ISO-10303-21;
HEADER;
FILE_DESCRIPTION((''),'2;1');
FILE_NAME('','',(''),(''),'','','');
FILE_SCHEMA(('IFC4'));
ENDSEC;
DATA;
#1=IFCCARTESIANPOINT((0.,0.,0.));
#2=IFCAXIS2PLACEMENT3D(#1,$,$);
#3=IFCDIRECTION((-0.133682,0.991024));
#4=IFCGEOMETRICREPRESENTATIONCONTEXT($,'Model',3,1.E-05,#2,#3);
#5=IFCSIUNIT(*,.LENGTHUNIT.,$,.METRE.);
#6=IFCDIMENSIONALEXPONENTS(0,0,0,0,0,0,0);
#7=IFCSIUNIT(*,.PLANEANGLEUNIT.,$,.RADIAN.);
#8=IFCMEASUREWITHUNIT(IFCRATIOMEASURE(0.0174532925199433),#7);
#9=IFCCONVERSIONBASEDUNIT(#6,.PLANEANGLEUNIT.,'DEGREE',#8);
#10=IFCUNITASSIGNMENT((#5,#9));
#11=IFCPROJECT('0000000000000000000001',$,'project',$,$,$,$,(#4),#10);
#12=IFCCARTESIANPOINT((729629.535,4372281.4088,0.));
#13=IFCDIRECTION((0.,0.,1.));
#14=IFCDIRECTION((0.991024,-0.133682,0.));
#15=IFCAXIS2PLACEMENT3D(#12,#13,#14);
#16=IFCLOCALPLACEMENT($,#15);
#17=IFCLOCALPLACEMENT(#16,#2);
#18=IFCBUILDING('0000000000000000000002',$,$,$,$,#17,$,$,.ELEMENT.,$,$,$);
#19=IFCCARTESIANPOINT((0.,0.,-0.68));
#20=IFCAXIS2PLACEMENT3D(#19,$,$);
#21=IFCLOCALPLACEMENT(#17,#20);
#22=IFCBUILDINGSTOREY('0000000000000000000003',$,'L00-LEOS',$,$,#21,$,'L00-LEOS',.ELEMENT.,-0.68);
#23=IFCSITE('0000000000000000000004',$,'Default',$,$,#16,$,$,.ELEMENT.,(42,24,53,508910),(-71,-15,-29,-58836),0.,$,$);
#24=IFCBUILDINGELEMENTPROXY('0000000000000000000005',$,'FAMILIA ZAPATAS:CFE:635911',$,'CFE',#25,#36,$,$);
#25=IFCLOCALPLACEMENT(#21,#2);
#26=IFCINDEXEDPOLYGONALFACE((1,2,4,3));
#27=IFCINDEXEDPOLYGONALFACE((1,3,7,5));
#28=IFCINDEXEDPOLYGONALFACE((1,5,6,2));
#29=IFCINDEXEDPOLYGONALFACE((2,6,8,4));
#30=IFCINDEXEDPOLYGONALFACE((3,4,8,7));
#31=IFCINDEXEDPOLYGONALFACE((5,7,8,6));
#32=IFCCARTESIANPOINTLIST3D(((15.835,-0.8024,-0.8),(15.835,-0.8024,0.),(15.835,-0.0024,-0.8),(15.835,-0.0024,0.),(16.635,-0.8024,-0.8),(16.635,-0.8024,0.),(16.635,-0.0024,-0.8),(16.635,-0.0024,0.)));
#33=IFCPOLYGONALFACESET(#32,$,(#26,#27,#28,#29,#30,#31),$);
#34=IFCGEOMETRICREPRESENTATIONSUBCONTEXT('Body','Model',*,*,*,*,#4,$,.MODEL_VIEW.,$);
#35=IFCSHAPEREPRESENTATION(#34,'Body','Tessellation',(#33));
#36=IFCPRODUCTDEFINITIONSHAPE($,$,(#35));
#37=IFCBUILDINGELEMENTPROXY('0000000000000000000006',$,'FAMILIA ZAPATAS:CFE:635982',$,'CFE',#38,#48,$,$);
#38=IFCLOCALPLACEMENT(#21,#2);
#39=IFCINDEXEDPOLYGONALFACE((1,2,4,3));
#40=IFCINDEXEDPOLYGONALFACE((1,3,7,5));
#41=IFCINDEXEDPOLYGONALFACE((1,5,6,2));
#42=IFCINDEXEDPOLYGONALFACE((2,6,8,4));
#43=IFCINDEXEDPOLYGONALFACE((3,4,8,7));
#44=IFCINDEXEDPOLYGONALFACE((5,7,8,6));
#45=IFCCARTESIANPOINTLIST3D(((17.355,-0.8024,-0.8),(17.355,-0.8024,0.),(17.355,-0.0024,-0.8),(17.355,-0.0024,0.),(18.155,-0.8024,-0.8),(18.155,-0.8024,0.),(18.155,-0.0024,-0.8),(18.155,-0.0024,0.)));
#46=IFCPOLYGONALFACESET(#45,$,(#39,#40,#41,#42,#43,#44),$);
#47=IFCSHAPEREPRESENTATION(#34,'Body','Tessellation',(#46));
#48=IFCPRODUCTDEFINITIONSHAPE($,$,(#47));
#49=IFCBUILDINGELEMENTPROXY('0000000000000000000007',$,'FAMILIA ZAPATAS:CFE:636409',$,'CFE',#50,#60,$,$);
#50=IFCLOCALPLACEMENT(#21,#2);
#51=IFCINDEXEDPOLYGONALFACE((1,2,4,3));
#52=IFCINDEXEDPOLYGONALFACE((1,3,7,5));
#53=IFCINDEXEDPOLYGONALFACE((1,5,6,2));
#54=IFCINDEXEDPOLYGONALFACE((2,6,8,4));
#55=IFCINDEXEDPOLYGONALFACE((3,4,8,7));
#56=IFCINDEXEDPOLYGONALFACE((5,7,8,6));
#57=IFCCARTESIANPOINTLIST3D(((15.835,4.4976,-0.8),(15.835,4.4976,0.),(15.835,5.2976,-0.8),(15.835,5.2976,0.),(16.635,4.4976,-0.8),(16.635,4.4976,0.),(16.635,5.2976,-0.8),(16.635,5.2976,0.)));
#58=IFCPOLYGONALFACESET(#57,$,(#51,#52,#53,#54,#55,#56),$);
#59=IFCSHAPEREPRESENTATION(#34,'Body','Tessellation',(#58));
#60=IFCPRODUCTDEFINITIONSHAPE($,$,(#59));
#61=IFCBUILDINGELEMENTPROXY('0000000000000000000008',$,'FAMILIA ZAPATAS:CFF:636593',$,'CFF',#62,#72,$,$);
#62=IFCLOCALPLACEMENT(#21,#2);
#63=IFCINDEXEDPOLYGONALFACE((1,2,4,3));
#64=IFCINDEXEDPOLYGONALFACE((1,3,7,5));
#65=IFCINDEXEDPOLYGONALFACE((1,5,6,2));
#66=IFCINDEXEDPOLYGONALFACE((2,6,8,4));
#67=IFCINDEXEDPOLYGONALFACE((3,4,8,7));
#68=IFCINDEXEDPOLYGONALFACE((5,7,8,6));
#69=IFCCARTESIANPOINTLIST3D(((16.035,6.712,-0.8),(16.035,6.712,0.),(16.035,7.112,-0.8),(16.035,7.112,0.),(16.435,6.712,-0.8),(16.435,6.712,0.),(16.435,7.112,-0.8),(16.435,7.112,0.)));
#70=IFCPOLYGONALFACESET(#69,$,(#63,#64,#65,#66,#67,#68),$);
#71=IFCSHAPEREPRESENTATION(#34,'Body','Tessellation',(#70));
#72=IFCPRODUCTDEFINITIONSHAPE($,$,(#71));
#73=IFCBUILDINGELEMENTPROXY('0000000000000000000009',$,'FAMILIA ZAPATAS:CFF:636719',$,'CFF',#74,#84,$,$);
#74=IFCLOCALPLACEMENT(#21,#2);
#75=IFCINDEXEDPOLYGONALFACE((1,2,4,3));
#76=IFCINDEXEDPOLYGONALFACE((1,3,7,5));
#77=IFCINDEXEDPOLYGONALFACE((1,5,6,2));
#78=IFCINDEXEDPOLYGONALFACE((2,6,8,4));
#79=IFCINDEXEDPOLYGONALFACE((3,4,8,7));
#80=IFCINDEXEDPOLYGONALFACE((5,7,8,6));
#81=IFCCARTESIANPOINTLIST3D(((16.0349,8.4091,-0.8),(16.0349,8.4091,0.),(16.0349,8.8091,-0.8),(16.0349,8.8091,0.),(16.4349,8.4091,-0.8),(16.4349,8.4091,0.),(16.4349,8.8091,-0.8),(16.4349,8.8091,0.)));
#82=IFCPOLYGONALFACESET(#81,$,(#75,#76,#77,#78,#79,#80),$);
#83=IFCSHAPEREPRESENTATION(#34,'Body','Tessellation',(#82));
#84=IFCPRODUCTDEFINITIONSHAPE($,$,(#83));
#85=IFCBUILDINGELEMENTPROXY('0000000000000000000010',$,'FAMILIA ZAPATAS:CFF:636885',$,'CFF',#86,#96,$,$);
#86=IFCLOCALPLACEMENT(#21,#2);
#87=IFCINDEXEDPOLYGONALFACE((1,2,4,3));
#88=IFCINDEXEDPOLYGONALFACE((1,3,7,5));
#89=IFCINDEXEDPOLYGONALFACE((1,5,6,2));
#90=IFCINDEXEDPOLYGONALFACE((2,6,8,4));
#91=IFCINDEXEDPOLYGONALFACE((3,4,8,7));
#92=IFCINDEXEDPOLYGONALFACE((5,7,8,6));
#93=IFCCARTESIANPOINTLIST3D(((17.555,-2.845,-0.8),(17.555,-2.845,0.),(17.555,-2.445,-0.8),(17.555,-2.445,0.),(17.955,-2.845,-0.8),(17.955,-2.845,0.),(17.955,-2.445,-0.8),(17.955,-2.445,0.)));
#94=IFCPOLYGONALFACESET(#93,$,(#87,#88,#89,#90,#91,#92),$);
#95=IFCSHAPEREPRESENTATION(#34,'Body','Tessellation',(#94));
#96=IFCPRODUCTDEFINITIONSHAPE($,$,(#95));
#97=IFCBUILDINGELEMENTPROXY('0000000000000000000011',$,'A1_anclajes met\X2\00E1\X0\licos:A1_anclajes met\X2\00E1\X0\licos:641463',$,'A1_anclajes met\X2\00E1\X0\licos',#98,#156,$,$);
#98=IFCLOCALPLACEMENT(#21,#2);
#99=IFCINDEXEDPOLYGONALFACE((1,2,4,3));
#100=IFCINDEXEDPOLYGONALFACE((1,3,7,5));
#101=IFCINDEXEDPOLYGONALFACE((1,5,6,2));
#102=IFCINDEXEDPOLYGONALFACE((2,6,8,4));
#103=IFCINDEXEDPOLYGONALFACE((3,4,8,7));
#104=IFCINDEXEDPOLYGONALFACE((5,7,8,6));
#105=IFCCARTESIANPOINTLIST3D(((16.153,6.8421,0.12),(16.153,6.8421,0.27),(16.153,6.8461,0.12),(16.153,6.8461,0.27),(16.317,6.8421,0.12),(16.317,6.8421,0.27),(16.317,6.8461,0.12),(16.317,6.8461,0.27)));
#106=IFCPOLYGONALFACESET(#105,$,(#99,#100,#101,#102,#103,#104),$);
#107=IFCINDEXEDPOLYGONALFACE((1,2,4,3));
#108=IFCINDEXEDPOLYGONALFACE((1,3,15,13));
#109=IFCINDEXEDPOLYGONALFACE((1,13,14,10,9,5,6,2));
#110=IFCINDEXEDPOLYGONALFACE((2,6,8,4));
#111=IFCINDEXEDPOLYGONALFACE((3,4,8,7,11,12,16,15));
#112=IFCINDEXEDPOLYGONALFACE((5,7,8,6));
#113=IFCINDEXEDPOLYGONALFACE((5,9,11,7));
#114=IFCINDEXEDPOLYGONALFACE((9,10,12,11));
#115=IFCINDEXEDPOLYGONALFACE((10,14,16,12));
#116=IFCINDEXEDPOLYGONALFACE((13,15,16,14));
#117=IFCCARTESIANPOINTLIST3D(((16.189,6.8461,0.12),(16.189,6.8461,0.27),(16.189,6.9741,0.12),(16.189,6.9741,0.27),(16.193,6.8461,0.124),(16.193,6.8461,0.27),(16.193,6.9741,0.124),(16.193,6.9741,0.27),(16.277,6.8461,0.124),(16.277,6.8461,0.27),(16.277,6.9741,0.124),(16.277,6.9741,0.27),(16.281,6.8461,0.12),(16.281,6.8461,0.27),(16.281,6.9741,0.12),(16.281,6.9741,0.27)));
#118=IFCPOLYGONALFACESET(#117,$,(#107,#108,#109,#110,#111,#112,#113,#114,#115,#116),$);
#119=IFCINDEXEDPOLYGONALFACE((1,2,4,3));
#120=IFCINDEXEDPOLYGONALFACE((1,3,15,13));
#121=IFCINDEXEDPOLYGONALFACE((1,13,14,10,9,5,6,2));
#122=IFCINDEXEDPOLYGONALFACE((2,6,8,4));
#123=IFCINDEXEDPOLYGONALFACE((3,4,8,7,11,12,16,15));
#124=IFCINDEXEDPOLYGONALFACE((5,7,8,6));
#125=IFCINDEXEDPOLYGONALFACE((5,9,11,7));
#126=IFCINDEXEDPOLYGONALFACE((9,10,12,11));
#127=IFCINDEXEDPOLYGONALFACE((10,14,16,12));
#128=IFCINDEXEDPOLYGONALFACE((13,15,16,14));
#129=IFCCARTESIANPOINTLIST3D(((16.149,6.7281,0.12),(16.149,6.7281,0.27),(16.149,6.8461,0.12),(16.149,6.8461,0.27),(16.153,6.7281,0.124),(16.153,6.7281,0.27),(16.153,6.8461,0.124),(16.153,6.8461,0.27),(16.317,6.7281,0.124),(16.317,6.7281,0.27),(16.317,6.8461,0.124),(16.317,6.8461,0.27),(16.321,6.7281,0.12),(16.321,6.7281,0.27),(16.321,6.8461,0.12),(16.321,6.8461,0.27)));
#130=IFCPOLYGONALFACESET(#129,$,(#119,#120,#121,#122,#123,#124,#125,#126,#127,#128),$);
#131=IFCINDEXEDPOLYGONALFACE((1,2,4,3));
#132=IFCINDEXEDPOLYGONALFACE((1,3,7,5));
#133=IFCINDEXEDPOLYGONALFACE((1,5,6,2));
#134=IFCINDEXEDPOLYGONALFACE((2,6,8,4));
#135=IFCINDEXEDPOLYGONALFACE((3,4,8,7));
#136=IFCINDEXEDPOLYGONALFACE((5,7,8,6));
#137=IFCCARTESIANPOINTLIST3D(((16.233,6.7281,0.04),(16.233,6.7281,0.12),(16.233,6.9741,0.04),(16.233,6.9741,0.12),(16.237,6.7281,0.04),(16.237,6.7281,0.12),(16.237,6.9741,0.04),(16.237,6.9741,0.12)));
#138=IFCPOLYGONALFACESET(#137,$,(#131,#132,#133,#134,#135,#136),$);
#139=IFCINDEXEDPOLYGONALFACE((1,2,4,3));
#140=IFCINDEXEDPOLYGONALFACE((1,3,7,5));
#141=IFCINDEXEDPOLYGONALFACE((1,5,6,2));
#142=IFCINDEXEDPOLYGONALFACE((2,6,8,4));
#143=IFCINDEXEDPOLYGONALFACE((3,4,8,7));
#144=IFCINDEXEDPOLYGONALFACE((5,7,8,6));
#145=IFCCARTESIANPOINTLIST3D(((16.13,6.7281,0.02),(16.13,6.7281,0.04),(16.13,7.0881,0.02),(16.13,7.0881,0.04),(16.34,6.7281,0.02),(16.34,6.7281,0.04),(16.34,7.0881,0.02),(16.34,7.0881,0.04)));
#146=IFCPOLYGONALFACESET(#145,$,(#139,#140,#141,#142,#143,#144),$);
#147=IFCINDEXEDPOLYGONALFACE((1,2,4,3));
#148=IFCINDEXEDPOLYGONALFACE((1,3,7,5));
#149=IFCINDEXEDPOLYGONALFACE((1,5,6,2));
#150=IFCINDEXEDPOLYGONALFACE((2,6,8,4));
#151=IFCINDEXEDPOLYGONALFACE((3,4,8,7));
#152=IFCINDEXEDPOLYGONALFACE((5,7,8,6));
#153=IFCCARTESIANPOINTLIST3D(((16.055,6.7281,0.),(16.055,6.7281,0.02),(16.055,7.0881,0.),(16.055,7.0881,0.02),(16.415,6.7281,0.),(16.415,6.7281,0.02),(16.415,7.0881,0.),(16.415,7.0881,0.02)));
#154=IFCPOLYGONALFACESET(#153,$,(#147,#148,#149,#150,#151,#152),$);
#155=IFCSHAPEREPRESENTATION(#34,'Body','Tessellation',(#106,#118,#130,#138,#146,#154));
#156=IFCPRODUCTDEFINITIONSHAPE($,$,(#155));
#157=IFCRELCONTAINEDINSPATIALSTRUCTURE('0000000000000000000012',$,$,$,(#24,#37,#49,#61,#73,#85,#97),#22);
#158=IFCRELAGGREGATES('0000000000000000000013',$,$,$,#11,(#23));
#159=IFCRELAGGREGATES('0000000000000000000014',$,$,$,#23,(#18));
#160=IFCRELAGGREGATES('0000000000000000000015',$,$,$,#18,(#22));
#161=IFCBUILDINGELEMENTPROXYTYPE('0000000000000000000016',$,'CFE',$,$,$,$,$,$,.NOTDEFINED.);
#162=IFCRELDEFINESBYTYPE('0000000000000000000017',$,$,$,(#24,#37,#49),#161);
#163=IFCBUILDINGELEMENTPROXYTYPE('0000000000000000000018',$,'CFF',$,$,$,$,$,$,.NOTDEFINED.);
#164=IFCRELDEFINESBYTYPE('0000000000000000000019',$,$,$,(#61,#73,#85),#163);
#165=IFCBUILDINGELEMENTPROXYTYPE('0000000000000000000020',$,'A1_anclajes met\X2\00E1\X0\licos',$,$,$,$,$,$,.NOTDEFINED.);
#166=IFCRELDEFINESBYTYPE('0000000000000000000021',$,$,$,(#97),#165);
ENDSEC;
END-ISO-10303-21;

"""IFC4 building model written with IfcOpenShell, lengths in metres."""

from ifc_helpers import new_model, entity, si_unit, converted_unit, direction, frame, frame_2d, origin, origin_2d_with_axis, place, context, subcontext, project, spatial, polyline, rectangle, outline, extrude, source, transform, mapped, type_object, type_shapes, element, save


model = new_model("IFC4")

# Units and contexts
model_context = context("Model", 3, precision=1e-05, world=origin(), true_north=direction((-0.133682, 0.991024)))
body_context = subcontext(model_context, "Body", "Model", "MODEL_VIEW")
ifc_project = project(units=[si_unit("LENGTHUNIT", "METRE"), converted_unit("PLANEANGLEUNIT", "DEGREE", entity("IfcRatioMeasure", 0.0174532925199433), si_unit("PLANEANGLEUNIT", "RADIAN"), dimensions=[0, 0, 0, 0, 0, 0, 0])], contexts=[model_context])

# Site, building, storey
site_placement = place(None, frame((729629.535, 4372281.4088, 0.0), z_axis=(0.0, 0.0, 1.0), x_axis=(0.991024, -0.133682, 0.0)))
site = spatial("IfcSite", under=ifc_project, at=site_placement, Name="Default", CompositionType="ELEMENT", RefLatitude=(42, 24, 53, 508910), RefLongitude=(-71, -15, -29, -58836), RefElevation=0.0)
building_placement = place(site_placement, origin())
building = spatial("IfcBuilding", under=site, at=building_placement, CompositionType="ELEMENT")
storey_placement = place(building_placement, frame((0.0, 0.0, -0.68)))
storey = spatial("IfcBuildingStorey", under=building, at=storey_placement, Name="L00-LEOS", LongName="L00-LEOS", CompositionType="ELEMENT", Elevation=-0.68)

# Building element proxies
building_element_proxy_type_1 = type_object("IfcBuildingElementProxyType", Name="CFE")
shared_shape_1 = source(origin(), body_context, "Body", "SweptSolid", [
    extrude(rectangle(XDim=0.8, YDim=0.8, at=origin_2d_with_axis()), frame((0.0, 0.0, 0.0), z_axis=(0.0, 0.0, 1.0), x_axis=(0.0, -1.0, 0.0)), (0.0, 0.0, 1.0), 0.8),
])
type_shapes(building_element_proxy_type_1, [shared_shape_1])
for number, where, name in (
    (1, (16.235, -0.4024, -0.8), "FAMILIA ZAPATAS:CFE:635911"),
    (2, (17.755, -0.4024, -0.8), "FAMILIA ZAPATAS:CFE:635982"),
    (3, (16.235, 4.8976, -0.8), "FAMILIA ZAPATAS:CFE:636409"),
):
    element("IfcBuildingElementProxy", number, at=place(storey_placement, frame(where)), inside=storey, type_object=building_element_proxy_type_1, Name=name, ObjectType="CFE", context=body_context, shape_type="MappedRepresentation", body=[
        mapped(shared_shape_1, transform((0.0, 0.0, 0.0), scale=1.0)),
    ])
building_element_proxy_type_2 = type_object("IfcBuildingElementProxyType", Name="CFF")
shared_shape_2 = source(origin(), body_context, "Body", "SweptSolid", [
    extrude(rectangle(XDim=0.4, YDim=0.4, at=origin_2d_with_axis()), frame((0.0, 0.0, 0.0), z_axis=(0.0, 0.0, 1.0), x_axis=(0.0, -1.0, 0.0)), (0.0, 0.0, 1.0), 0.8),
])
type_shapes(building_element_proxy_type_2, [shared_shape_2])
for number, where, name in (
    (4, (16.235, 6.912, -0.8), "FAMILIA ZAPATAS:CFF:636593"),
    (5, (16.2349, 8.6091, -0.8), "FAMILIA ZAPATAS:CFF:636719"),
    (6, (17.755, -2.645, -0.8), "FAMILIA ZAPATAS:CFF:636885"),
):
    element("IfcBuildingElementProxy", number, at=place(storey_placement, frame(where)), inside=storey, type_object=building_element_proxy_type_2, Name=name, ObjectType="CFF", context=body_context, shape_type="MappedRepresentation", body=[
        mapped(shared_shape_2, transform((0.0, 0.0, 0.0), scale=1.0)),
    ])
building_element_proxy_type_3 = type_object("IfcBuildingElementProxyType", Name="A1_anclajes metálicos")
shared_shape_3 = source(origin(), body_context, "Body", "SweptSolid", [
    extrude(rectangle(XDim=0.164, YDim=0.004, at=frame_2d((0.0, 0.0), x_axis=(1.0, 0.0))), frame((-0.064, 0.0, 0.12), z_axis=(0.0, 0.0, 1.0), x_axis=(0.0, -1.0, 0.0)), (0.0, 0.0, 1.0), 0.15),
    extrude(outline(polyline([(-0.076, -0.046), (0.074, -0.046), (0.074, -0.042), (-0.072, -0.042), (-0.072, 0.042), (0.074, 0.042), (0.074, 0.046), (-0.076, 0.046), (-0.076, -0.046)])), frame((-0.062, 0.0, 0.196), z_axis=(1.0, 0.0, 0.0), x_axis=(0.0, 0.0, 1.0)), (0.0, 0.0, 1.0), 0.128),
    extrude(outline(polyline([(-0.076, -0.086), (0.074, -0.086), (0.074, -0.082), (-0.072, -0.082), (-0.072, 0.082), (0.074, 0.082), (0.074, 0.086), (-0.076, 0.086), (-0.076, -0.086)])), frame((-0.18, 0.0, 0.196), z_axis=(1.0, 0.0, 0.0), x_axis=(0.0, 0.0, 1.0)), (0.0, 0.0, 1.0), 0.118),
    extrude(rectangle(XDim=0.004, YDim=0.246, at=origin_2d_with_axis()), frame((-0.057, 0.0, 0.04), z_axis=(0.0, 0.0, 1.0), x_axis=(0.0, -1.0, 0.0)), (0.0, 0.0, 1.0), 0.08),
    extrude(rectangle(XDim=0.36, YDim=0.21, at=frame_2d((0.0, 0.0), x_axis=(1.0, 0.0))), frame((0.0, 0.0, 0.02), z_axis=(0.0, 0.0, 1.0), x_axis=(-1.0, 0.0, 0.0)), (0.0, 0.0, 1.0), 0.02),
    extrude(rectangle(XDim=0.36, YDim=0.36, at=frame_2d((0.0, 0.0), x_axis=(1.0, 0.0))), frame((0.0, 0.0, 0.0), z_axis=(0.0, 0.0, 1.0), x_axis=(-1.0, 0.0, 0.0)), (0.0, 0.0, 1.0), 0.02),
])
type_shapes(building_element_proxy_type_3, [shared_shape_3])
proxy_1_placement = place(storey_placement, frame((16.235, 6.9081, 0.0), z_axis=(0.0, 0.0, 1.0), x_axis=(0.0, 1.0, 0.0)))
element("IfcBuildingElementProxy", 7, at=proxy_1_placement, inside=storey, type_object=building_element_proxy_type_3, Name="A1_anclajes metálicos:A1_anclajes metálicos:641463", ObjectType="A1_anclajes metálicos", context=body_context, shape_type="MappedRepresentation", body=[
    mapped(shared_shape_3, transform((0.0, 0.0, 0.0), scale=1.0)),
])

save(model, "model.ifc")
